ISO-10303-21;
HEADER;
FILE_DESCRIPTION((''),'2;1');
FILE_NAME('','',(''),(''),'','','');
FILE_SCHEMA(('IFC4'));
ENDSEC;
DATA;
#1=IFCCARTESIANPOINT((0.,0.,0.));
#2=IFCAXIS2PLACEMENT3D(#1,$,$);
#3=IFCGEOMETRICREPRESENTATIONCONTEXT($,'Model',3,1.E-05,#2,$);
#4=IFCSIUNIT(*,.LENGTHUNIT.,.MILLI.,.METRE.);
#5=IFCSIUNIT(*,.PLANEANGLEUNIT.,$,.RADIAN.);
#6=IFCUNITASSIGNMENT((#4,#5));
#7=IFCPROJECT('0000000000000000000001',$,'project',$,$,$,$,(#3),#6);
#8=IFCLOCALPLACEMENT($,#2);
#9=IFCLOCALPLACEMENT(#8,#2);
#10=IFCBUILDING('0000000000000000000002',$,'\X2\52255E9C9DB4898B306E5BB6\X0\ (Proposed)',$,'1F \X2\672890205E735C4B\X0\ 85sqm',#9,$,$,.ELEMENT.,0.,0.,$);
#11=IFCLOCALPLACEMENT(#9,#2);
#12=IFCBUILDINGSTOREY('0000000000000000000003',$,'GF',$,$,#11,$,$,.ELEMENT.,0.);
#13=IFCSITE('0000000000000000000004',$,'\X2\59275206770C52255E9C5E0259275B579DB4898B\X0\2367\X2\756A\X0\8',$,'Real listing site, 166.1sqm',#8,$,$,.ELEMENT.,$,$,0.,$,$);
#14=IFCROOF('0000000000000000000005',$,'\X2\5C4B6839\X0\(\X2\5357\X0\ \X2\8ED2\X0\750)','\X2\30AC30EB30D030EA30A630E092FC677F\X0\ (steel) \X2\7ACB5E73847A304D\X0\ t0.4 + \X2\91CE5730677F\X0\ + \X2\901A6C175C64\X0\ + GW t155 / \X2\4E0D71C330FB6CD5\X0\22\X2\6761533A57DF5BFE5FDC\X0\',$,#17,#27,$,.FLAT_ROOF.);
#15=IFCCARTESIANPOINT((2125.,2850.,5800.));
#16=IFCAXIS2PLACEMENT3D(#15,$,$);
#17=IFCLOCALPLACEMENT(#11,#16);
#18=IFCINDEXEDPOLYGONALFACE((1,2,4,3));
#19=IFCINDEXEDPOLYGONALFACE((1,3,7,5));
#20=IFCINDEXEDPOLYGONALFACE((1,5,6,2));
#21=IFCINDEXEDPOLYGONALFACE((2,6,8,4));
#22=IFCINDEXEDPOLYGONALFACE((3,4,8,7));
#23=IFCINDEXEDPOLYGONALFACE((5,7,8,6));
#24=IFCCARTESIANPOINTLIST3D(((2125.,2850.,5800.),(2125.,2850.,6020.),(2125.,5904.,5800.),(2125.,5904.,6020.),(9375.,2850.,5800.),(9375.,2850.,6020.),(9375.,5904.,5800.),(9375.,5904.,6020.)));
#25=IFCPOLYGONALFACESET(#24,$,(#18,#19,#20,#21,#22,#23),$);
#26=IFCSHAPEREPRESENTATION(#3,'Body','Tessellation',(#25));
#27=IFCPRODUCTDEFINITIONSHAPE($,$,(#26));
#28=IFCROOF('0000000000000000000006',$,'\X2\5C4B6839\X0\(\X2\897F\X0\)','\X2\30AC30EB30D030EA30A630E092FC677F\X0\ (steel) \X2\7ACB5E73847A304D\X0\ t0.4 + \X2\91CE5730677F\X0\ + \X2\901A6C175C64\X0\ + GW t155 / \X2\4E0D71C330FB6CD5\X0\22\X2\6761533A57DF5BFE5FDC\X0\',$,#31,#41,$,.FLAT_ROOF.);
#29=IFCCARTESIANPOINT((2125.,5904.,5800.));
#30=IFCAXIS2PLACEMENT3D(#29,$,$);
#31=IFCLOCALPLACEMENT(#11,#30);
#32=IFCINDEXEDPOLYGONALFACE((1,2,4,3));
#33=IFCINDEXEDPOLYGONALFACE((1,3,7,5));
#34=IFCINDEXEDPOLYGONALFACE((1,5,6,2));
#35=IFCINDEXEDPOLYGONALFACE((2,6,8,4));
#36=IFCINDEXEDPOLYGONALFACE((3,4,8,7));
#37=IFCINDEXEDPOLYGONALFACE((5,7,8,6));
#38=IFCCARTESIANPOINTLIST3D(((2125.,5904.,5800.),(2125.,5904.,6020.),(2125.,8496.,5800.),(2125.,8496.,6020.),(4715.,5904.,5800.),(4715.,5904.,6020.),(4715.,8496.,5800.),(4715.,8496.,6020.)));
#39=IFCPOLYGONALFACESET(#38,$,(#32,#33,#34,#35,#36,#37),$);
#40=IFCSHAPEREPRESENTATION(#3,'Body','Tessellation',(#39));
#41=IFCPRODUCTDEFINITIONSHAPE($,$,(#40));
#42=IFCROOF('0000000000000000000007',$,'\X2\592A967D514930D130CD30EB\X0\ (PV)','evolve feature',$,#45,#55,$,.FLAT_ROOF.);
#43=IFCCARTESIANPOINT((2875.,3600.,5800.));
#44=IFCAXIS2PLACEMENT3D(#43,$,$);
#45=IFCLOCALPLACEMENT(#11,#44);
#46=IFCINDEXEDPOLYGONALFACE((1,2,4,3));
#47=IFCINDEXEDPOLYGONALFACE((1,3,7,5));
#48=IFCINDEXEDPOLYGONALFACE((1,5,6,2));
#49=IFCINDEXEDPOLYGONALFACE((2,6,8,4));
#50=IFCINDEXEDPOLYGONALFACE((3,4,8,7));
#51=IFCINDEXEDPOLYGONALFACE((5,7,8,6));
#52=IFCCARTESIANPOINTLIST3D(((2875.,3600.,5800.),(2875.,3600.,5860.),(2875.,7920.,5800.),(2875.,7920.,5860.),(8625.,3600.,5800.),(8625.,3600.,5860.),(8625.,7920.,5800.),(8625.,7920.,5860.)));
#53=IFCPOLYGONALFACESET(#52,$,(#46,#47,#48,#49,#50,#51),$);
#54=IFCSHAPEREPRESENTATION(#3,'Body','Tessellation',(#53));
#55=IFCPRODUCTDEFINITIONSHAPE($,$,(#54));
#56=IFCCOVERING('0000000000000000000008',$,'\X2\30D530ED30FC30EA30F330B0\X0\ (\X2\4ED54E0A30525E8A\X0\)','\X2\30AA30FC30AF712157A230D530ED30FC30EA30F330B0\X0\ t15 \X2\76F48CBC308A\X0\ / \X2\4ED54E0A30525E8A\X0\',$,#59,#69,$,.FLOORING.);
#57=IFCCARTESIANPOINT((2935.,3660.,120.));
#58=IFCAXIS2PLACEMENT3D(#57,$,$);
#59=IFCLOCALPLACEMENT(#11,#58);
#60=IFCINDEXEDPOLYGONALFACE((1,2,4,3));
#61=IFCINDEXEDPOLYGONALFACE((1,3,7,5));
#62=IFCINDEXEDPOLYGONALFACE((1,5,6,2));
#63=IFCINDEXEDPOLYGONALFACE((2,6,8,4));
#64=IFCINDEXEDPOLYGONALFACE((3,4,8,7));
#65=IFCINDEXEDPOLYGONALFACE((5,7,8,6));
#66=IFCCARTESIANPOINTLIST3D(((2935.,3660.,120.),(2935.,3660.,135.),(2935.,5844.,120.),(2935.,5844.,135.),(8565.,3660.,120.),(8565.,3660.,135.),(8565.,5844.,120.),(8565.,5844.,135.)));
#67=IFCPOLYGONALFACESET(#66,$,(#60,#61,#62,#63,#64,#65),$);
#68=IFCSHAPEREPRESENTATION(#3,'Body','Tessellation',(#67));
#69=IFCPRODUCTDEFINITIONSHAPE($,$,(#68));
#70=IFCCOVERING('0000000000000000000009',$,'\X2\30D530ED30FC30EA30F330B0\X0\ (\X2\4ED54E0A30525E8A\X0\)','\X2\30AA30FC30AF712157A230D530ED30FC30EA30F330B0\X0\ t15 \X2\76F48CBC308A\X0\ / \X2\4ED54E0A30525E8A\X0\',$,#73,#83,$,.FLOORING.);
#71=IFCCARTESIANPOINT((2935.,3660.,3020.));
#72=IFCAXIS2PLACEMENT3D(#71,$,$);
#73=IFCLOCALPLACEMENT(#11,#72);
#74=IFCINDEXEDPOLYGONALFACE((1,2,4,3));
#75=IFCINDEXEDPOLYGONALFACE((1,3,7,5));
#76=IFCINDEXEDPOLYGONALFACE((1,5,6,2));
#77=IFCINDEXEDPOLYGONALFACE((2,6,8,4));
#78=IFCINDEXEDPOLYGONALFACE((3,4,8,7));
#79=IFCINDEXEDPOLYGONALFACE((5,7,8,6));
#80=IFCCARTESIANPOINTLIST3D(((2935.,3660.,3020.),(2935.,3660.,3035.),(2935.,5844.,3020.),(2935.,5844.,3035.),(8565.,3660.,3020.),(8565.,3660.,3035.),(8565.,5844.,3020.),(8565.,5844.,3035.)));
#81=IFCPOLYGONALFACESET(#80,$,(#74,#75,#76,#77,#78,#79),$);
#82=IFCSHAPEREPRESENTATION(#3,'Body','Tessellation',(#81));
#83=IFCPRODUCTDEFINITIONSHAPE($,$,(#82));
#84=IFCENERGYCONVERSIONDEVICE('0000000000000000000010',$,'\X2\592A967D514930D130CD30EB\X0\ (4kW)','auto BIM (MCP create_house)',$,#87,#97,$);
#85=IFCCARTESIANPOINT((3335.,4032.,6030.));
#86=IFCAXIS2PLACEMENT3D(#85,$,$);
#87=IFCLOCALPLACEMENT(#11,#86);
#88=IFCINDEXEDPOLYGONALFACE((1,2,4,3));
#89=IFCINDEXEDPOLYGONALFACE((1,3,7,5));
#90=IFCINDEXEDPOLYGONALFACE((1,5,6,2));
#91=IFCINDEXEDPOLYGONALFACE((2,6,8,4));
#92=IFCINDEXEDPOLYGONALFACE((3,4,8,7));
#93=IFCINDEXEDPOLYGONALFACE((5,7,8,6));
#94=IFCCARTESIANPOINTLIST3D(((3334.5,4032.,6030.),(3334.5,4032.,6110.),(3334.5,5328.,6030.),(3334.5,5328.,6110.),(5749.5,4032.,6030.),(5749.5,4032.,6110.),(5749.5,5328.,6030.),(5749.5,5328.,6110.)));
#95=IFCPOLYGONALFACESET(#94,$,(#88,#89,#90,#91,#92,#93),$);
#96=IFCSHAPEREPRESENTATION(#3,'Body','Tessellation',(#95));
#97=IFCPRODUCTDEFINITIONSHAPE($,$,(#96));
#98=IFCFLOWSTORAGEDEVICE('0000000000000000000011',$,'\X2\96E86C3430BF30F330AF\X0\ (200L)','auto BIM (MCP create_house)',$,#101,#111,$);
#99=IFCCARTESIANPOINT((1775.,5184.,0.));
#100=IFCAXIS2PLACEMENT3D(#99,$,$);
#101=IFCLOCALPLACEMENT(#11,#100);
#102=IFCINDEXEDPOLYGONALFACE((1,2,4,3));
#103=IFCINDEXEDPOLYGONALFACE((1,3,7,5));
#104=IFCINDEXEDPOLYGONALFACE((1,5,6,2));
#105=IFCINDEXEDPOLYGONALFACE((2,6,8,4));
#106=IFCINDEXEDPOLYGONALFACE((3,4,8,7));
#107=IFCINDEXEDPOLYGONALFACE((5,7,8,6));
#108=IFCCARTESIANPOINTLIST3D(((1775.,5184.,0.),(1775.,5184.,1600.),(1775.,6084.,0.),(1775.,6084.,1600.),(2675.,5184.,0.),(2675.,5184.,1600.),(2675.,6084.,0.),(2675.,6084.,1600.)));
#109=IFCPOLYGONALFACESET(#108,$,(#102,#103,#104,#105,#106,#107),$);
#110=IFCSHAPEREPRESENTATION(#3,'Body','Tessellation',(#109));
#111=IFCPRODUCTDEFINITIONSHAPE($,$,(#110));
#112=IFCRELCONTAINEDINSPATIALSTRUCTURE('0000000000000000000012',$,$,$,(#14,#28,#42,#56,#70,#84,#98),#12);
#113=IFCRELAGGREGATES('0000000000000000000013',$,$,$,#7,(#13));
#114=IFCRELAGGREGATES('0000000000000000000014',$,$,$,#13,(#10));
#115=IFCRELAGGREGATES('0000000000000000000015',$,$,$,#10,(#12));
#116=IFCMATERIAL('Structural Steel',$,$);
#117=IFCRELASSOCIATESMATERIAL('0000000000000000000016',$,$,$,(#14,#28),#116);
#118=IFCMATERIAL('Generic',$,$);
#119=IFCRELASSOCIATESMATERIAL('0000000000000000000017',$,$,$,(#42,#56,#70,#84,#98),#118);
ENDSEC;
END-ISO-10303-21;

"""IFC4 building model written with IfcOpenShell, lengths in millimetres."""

from ifc_helpers import new_model, si_unit, frame, frame_2d, origin, place, context, project, spatial, rectangle, extrude, material, element, save


model = new_model("IFC4")

# Units and contexts
model_context = context("Model", 3, precision=1e-05, world=origin())
ifc_project = project(units=[si_unit("LENGTHUNIT", "METRE", prefix="MILLI"), si_unit("PLANEANGLEUNIT", "RADIAN")], contexts=[model_context])

# Site, building, storey
site_placement = place(None, origin())
site = spatial("IfcSite", under=ifc_project, at=site_placement, Name="大分県別府市大字鶴見2367番8", ObjectType="Real listing site, 166.1sqm", CompositionType="ELEMENT", RefElevation=0.0)
building_placement = place(site_placement, origin())
building = spatial("IfcBuilding", under=site, at=building_placement, Name="別府鶴見の家 (Proposed)", ObjectType="1F 木造平屋 85sqm", CompositionType="ELEMENT", ElevationOfRefHeight=0.0, ElevationOfTerrain=0.0)
storey_placement = place(building_placement, origin())
storey = spatial("IfcBuildingStorey", under=building, at=storey_placement, Name="GF", CompositionType="ELEMENT", Elevation=0.0)

# Shared definitions
ifc_material_1 = material(Name="Generic")

# Roofs
ifc_material_2 = material(Name="Structural Steel")
roof_1_placement = place(storey_placement, frame((2125.0, 2850.0, 5800.0)))
element("IfcRoof", 1, at=roof_1_placement, inside=storey, material=ifc_material_2, Name="屋根(南 軒750)", Description="ガルバリウム鋼板 (steel) 立平葺き t0.4 + 野地板 + 通気層 + GW t155 / 不燃・法22条区域対応", PredefinedType="FLAT_ROOF", context=model_context, shape_type="SweptSolid", body=[
    extrude(rectangle(XDim=7250.0, YDim=3054.0, at=frame_2d((3625.0, 1527.0))), frame((2125.0, 2850.0, 5800.0)), (0.0, 0.0, 1.0), 220.0),
])
roof_2_placement = place(storey_placement, frame((2125.0, 5904.0, 5800.0)))
element("IfcRoof", 2, at=roof_2_placement, inside=storey, material=ifc_material_2, Name="屋根(西)", Description="ガルバリウム鋼板 (steel) 立平葺き t0.4 + 野地板 + 通気層 + GW t155 / 不燃・法22条区域対応", PredefinedType="FLAT_ROOF", context=model_context, shape_type="SweptSolid", body=[
    extrude(rectangle(XDim=2590.0, YDim=2592.0, at=frame_2d((1295.0, 1296.0))), frame((2125.0, 5904.0, 5800.0)), (0.0, 0.0, 1.0), 220.0),
])
roof_3_placement = place(storey_placement, frame((2875.0, 3600.0, 5800.0)))
element("IfcRoof", 3, at=roof_3_placement, inside=storey, material=ifc_material_1, Name="太陽光パネル (PV)", Description="evolve feature", PredefinedType="FLAT_ROOF", context=model_context, shape_type="SweptSolid", body=[
    extrude(rectangle(XDim=5750.0, YDim=4320.0, at=frame_2d((2875.0, 2160.0))), frame((2875.0, 3600.0, 5800.0)), (0.0, 0.0, 1.0), 60.0),
])

# Coverings
covering_1_placement = place(storey_placement, frame((2935.0, 3660.0, 120.0)))
element("IfcCovering", 4, at=covering_1_placement, inside=storey, material=ifc_material_1, Name="フローリング (仕上げ床)", Description="オーク無垢フローリング t15 直貼り / 仕上げ床", PredefinedType="FLOORING", context=model_context, shape_type="SweptSolid", body=[
    extrude(rectangle(XDim=5630.0, YDim=2184.0, at=frame_2d((2815.0, 1092.0))), frame((2935.0, 3660.0, 120.0)), (0.0, 0.0, 1.0), 15.0),
])
covering_2_placement = place(storey_placement, frame((2935.0, 3660.0, 3020.0)))
element("IfcCovering", 5, at=covering_2_placement, inside=storey, material=ifc_material_1, Name="フローリング (仕上げ床)", Description="オーク無垢フローリング t15 直貼り / 仕上げ床", PredefinedType="FLOORING", context=model_context, shape_type="SweptSolid", body=[
    extrude(rectangle(XDim=5630.0, YDim=2184.0, at=frame_2d((2815.0, 1092.0))), frame((2935.0, 3660.0, 3020.0)), (0.0, 0.0, 1.0), 15.0),
])

# Energy conversion device
energy_conversion_device_placement = place(storey_placement, frame((3335.0, 4032.0, 6030.0)))
element("IfcEnergyConversionDevice", 6, at=energy_conversion_device_placement, inside=storey, material=ifc_material_1, Name="太陽光パネル (4kW)", Description="auto BIM (MCP create_house)", context=model_context, shape_type="SweptSolid", body=[
    extrude(rectangle(XDim=2415.0, YDim=1296.0, at=frame_2d((1207.0, 648.0))), frame((3335.0, 4032.0, 6030.0)), (0.0, 0.0, 1.0), 80.0),
])

# Flow storage device
flow_storage_device_placement = place(storey_placement, frame((1775.0, 5184.0, 0.0)))
element("IfcFlowStorageDevice", 7, at=flow_storage_device_placement, inside=storey, material=ifc_material_1, Name="雨水タンク (200L)", Description="auto BIM (MCP create_house)", context=model_context, shape_type="SweptSolid", body=[
    extrude(rectangle(XDim=900.0, YDim=900.0, at=frame_2d((450.0, 450.0))), frame((1775.0, 5184.0, 0.0)), (0.0, 0.0, 1.0), 1600.0),
])

save(model, "model.ifc")
